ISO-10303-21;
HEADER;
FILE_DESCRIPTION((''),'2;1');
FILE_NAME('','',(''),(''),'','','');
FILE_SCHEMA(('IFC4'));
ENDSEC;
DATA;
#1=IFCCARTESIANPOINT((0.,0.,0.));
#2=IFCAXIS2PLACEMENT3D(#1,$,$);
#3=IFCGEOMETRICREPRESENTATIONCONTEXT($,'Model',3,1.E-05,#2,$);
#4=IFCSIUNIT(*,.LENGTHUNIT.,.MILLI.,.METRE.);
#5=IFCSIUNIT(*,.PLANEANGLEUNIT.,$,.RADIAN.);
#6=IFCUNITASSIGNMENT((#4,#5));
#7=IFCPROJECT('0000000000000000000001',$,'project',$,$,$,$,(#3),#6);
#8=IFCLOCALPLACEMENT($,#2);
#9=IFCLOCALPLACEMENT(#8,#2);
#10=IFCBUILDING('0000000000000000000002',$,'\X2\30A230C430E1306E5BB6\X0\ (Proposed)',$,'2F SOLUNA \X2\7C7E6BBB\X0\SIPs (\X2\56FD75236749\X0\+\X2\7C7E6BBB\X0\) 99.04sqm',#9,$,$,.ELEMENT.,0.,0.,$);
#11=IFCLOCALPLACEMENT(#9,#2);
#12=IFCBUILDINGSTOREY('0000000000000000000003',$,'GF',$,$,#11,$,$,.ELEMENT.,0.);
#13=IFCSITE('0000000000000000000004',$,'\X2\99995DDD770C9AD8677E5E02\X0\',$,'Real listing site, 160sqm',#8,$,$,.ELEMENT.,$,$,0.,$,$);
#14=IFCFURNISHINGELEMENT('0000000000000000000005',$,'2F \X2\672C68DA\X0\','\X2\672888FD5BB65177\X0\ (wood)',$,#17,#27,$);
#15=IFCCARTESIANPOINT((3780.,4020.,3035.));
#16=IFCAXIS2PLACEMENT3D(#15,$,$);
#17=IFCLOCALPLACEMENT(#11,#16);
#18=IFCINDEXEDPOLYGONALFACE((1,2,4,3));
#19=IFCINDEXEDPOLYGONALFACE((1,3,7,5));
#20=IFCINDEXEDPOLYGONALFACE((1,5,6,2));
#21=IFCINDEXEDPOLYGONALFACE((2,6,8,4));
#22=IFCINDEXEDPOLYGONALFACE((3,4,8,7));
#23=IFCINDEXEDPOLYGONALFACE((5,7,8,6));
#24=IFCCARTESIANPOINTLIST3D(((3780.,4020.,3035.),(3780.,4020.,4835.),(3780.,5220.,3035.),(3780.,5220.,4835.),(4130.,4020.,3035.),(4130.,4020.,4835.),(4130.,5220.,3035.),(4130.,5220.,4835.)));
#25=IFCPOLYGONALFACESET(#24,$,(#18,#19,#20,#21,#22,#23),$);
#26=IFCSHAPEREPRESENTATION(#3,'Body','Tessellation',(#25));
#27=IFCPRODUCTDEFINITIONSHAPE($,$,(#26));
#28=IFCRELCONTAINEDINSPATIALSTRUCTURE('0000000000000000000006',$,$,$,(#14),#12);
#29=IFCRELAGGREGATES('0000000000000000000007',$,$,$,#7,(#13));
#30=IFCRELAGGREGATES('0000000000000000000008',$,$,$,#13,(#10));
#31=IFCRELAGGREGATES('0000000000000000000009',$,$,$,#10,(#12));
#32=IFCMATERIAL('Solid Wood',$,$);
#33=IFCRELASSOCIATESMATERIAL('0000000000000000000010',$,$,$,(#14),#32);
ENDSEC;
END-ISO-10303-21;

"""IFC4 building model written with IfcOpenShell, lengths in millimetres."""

from ifc_helpers import new_model, si_unit, frame, frame_2d, origin, place, context, project, spatial, rectangle, extrude, material, element, save


model = new_model("IFC4")

# Units and contexts
model_context = context("Model", 3, precision=1e-05, world=origin())
ifc_project = project(units=[si_unit("LENGTHUNIT", "METRE", prefix="MILLI"), si_unit("PLANEANGLEUNIT", "RADIAN")], contexts=[model_context])

# Site, building, storey
site_placement = place(None, origin())
site = spatial("IfcSite", under=ifc_project, at=site_placement, Name="香川県高松市", ObjectType="Real listing site, 160sqm", CompositionType="ELEMENT", RefElevation=0.0)
building_placement = place(site_placement, origin())
building = spatial("IfcBuilding", under=site, at=building_placement, Name="アツメの家 (Proposed)", ObjectType="2F SOLUNA 籾殻SIPs (国産杉+籾殻) 99.04sqm", CompositionType="ELEMENT", ElevationOfRefHeight=0.0, ElevationOfTerrain=0.0)
storey_placement = place(building_placement, origin())
storey = spatial("IfcBuildingStorey", under=building, at=storey_placement, Name="GF", CompositionType="ELEMENT", Elevation=0.0)

# Shared definitions
ifc_material_1 = material(Name="Solid Wood")

# Furnishing element
furnishing_placement = place(storey_placement, frame((3780.0, 4020.0, 3035.0)))
element("IfcFurnishingElement", 1, at=furnishing_placement, inside=storey, material=ifc_material_1, Name="2F 本棚", Description="木製家具 (wood)", context=model_context, shape_type="SweptSolid", body=[
    extrude(rectangle(XDim=350.0, YDim=1200.0, at=frame_2d((175.0, 600.0))), frame((3780.0, 4020.0, 3035.0)), (0.0, 0.0, 1.0), 1800.0),
])

save(model, "model.ifc")
